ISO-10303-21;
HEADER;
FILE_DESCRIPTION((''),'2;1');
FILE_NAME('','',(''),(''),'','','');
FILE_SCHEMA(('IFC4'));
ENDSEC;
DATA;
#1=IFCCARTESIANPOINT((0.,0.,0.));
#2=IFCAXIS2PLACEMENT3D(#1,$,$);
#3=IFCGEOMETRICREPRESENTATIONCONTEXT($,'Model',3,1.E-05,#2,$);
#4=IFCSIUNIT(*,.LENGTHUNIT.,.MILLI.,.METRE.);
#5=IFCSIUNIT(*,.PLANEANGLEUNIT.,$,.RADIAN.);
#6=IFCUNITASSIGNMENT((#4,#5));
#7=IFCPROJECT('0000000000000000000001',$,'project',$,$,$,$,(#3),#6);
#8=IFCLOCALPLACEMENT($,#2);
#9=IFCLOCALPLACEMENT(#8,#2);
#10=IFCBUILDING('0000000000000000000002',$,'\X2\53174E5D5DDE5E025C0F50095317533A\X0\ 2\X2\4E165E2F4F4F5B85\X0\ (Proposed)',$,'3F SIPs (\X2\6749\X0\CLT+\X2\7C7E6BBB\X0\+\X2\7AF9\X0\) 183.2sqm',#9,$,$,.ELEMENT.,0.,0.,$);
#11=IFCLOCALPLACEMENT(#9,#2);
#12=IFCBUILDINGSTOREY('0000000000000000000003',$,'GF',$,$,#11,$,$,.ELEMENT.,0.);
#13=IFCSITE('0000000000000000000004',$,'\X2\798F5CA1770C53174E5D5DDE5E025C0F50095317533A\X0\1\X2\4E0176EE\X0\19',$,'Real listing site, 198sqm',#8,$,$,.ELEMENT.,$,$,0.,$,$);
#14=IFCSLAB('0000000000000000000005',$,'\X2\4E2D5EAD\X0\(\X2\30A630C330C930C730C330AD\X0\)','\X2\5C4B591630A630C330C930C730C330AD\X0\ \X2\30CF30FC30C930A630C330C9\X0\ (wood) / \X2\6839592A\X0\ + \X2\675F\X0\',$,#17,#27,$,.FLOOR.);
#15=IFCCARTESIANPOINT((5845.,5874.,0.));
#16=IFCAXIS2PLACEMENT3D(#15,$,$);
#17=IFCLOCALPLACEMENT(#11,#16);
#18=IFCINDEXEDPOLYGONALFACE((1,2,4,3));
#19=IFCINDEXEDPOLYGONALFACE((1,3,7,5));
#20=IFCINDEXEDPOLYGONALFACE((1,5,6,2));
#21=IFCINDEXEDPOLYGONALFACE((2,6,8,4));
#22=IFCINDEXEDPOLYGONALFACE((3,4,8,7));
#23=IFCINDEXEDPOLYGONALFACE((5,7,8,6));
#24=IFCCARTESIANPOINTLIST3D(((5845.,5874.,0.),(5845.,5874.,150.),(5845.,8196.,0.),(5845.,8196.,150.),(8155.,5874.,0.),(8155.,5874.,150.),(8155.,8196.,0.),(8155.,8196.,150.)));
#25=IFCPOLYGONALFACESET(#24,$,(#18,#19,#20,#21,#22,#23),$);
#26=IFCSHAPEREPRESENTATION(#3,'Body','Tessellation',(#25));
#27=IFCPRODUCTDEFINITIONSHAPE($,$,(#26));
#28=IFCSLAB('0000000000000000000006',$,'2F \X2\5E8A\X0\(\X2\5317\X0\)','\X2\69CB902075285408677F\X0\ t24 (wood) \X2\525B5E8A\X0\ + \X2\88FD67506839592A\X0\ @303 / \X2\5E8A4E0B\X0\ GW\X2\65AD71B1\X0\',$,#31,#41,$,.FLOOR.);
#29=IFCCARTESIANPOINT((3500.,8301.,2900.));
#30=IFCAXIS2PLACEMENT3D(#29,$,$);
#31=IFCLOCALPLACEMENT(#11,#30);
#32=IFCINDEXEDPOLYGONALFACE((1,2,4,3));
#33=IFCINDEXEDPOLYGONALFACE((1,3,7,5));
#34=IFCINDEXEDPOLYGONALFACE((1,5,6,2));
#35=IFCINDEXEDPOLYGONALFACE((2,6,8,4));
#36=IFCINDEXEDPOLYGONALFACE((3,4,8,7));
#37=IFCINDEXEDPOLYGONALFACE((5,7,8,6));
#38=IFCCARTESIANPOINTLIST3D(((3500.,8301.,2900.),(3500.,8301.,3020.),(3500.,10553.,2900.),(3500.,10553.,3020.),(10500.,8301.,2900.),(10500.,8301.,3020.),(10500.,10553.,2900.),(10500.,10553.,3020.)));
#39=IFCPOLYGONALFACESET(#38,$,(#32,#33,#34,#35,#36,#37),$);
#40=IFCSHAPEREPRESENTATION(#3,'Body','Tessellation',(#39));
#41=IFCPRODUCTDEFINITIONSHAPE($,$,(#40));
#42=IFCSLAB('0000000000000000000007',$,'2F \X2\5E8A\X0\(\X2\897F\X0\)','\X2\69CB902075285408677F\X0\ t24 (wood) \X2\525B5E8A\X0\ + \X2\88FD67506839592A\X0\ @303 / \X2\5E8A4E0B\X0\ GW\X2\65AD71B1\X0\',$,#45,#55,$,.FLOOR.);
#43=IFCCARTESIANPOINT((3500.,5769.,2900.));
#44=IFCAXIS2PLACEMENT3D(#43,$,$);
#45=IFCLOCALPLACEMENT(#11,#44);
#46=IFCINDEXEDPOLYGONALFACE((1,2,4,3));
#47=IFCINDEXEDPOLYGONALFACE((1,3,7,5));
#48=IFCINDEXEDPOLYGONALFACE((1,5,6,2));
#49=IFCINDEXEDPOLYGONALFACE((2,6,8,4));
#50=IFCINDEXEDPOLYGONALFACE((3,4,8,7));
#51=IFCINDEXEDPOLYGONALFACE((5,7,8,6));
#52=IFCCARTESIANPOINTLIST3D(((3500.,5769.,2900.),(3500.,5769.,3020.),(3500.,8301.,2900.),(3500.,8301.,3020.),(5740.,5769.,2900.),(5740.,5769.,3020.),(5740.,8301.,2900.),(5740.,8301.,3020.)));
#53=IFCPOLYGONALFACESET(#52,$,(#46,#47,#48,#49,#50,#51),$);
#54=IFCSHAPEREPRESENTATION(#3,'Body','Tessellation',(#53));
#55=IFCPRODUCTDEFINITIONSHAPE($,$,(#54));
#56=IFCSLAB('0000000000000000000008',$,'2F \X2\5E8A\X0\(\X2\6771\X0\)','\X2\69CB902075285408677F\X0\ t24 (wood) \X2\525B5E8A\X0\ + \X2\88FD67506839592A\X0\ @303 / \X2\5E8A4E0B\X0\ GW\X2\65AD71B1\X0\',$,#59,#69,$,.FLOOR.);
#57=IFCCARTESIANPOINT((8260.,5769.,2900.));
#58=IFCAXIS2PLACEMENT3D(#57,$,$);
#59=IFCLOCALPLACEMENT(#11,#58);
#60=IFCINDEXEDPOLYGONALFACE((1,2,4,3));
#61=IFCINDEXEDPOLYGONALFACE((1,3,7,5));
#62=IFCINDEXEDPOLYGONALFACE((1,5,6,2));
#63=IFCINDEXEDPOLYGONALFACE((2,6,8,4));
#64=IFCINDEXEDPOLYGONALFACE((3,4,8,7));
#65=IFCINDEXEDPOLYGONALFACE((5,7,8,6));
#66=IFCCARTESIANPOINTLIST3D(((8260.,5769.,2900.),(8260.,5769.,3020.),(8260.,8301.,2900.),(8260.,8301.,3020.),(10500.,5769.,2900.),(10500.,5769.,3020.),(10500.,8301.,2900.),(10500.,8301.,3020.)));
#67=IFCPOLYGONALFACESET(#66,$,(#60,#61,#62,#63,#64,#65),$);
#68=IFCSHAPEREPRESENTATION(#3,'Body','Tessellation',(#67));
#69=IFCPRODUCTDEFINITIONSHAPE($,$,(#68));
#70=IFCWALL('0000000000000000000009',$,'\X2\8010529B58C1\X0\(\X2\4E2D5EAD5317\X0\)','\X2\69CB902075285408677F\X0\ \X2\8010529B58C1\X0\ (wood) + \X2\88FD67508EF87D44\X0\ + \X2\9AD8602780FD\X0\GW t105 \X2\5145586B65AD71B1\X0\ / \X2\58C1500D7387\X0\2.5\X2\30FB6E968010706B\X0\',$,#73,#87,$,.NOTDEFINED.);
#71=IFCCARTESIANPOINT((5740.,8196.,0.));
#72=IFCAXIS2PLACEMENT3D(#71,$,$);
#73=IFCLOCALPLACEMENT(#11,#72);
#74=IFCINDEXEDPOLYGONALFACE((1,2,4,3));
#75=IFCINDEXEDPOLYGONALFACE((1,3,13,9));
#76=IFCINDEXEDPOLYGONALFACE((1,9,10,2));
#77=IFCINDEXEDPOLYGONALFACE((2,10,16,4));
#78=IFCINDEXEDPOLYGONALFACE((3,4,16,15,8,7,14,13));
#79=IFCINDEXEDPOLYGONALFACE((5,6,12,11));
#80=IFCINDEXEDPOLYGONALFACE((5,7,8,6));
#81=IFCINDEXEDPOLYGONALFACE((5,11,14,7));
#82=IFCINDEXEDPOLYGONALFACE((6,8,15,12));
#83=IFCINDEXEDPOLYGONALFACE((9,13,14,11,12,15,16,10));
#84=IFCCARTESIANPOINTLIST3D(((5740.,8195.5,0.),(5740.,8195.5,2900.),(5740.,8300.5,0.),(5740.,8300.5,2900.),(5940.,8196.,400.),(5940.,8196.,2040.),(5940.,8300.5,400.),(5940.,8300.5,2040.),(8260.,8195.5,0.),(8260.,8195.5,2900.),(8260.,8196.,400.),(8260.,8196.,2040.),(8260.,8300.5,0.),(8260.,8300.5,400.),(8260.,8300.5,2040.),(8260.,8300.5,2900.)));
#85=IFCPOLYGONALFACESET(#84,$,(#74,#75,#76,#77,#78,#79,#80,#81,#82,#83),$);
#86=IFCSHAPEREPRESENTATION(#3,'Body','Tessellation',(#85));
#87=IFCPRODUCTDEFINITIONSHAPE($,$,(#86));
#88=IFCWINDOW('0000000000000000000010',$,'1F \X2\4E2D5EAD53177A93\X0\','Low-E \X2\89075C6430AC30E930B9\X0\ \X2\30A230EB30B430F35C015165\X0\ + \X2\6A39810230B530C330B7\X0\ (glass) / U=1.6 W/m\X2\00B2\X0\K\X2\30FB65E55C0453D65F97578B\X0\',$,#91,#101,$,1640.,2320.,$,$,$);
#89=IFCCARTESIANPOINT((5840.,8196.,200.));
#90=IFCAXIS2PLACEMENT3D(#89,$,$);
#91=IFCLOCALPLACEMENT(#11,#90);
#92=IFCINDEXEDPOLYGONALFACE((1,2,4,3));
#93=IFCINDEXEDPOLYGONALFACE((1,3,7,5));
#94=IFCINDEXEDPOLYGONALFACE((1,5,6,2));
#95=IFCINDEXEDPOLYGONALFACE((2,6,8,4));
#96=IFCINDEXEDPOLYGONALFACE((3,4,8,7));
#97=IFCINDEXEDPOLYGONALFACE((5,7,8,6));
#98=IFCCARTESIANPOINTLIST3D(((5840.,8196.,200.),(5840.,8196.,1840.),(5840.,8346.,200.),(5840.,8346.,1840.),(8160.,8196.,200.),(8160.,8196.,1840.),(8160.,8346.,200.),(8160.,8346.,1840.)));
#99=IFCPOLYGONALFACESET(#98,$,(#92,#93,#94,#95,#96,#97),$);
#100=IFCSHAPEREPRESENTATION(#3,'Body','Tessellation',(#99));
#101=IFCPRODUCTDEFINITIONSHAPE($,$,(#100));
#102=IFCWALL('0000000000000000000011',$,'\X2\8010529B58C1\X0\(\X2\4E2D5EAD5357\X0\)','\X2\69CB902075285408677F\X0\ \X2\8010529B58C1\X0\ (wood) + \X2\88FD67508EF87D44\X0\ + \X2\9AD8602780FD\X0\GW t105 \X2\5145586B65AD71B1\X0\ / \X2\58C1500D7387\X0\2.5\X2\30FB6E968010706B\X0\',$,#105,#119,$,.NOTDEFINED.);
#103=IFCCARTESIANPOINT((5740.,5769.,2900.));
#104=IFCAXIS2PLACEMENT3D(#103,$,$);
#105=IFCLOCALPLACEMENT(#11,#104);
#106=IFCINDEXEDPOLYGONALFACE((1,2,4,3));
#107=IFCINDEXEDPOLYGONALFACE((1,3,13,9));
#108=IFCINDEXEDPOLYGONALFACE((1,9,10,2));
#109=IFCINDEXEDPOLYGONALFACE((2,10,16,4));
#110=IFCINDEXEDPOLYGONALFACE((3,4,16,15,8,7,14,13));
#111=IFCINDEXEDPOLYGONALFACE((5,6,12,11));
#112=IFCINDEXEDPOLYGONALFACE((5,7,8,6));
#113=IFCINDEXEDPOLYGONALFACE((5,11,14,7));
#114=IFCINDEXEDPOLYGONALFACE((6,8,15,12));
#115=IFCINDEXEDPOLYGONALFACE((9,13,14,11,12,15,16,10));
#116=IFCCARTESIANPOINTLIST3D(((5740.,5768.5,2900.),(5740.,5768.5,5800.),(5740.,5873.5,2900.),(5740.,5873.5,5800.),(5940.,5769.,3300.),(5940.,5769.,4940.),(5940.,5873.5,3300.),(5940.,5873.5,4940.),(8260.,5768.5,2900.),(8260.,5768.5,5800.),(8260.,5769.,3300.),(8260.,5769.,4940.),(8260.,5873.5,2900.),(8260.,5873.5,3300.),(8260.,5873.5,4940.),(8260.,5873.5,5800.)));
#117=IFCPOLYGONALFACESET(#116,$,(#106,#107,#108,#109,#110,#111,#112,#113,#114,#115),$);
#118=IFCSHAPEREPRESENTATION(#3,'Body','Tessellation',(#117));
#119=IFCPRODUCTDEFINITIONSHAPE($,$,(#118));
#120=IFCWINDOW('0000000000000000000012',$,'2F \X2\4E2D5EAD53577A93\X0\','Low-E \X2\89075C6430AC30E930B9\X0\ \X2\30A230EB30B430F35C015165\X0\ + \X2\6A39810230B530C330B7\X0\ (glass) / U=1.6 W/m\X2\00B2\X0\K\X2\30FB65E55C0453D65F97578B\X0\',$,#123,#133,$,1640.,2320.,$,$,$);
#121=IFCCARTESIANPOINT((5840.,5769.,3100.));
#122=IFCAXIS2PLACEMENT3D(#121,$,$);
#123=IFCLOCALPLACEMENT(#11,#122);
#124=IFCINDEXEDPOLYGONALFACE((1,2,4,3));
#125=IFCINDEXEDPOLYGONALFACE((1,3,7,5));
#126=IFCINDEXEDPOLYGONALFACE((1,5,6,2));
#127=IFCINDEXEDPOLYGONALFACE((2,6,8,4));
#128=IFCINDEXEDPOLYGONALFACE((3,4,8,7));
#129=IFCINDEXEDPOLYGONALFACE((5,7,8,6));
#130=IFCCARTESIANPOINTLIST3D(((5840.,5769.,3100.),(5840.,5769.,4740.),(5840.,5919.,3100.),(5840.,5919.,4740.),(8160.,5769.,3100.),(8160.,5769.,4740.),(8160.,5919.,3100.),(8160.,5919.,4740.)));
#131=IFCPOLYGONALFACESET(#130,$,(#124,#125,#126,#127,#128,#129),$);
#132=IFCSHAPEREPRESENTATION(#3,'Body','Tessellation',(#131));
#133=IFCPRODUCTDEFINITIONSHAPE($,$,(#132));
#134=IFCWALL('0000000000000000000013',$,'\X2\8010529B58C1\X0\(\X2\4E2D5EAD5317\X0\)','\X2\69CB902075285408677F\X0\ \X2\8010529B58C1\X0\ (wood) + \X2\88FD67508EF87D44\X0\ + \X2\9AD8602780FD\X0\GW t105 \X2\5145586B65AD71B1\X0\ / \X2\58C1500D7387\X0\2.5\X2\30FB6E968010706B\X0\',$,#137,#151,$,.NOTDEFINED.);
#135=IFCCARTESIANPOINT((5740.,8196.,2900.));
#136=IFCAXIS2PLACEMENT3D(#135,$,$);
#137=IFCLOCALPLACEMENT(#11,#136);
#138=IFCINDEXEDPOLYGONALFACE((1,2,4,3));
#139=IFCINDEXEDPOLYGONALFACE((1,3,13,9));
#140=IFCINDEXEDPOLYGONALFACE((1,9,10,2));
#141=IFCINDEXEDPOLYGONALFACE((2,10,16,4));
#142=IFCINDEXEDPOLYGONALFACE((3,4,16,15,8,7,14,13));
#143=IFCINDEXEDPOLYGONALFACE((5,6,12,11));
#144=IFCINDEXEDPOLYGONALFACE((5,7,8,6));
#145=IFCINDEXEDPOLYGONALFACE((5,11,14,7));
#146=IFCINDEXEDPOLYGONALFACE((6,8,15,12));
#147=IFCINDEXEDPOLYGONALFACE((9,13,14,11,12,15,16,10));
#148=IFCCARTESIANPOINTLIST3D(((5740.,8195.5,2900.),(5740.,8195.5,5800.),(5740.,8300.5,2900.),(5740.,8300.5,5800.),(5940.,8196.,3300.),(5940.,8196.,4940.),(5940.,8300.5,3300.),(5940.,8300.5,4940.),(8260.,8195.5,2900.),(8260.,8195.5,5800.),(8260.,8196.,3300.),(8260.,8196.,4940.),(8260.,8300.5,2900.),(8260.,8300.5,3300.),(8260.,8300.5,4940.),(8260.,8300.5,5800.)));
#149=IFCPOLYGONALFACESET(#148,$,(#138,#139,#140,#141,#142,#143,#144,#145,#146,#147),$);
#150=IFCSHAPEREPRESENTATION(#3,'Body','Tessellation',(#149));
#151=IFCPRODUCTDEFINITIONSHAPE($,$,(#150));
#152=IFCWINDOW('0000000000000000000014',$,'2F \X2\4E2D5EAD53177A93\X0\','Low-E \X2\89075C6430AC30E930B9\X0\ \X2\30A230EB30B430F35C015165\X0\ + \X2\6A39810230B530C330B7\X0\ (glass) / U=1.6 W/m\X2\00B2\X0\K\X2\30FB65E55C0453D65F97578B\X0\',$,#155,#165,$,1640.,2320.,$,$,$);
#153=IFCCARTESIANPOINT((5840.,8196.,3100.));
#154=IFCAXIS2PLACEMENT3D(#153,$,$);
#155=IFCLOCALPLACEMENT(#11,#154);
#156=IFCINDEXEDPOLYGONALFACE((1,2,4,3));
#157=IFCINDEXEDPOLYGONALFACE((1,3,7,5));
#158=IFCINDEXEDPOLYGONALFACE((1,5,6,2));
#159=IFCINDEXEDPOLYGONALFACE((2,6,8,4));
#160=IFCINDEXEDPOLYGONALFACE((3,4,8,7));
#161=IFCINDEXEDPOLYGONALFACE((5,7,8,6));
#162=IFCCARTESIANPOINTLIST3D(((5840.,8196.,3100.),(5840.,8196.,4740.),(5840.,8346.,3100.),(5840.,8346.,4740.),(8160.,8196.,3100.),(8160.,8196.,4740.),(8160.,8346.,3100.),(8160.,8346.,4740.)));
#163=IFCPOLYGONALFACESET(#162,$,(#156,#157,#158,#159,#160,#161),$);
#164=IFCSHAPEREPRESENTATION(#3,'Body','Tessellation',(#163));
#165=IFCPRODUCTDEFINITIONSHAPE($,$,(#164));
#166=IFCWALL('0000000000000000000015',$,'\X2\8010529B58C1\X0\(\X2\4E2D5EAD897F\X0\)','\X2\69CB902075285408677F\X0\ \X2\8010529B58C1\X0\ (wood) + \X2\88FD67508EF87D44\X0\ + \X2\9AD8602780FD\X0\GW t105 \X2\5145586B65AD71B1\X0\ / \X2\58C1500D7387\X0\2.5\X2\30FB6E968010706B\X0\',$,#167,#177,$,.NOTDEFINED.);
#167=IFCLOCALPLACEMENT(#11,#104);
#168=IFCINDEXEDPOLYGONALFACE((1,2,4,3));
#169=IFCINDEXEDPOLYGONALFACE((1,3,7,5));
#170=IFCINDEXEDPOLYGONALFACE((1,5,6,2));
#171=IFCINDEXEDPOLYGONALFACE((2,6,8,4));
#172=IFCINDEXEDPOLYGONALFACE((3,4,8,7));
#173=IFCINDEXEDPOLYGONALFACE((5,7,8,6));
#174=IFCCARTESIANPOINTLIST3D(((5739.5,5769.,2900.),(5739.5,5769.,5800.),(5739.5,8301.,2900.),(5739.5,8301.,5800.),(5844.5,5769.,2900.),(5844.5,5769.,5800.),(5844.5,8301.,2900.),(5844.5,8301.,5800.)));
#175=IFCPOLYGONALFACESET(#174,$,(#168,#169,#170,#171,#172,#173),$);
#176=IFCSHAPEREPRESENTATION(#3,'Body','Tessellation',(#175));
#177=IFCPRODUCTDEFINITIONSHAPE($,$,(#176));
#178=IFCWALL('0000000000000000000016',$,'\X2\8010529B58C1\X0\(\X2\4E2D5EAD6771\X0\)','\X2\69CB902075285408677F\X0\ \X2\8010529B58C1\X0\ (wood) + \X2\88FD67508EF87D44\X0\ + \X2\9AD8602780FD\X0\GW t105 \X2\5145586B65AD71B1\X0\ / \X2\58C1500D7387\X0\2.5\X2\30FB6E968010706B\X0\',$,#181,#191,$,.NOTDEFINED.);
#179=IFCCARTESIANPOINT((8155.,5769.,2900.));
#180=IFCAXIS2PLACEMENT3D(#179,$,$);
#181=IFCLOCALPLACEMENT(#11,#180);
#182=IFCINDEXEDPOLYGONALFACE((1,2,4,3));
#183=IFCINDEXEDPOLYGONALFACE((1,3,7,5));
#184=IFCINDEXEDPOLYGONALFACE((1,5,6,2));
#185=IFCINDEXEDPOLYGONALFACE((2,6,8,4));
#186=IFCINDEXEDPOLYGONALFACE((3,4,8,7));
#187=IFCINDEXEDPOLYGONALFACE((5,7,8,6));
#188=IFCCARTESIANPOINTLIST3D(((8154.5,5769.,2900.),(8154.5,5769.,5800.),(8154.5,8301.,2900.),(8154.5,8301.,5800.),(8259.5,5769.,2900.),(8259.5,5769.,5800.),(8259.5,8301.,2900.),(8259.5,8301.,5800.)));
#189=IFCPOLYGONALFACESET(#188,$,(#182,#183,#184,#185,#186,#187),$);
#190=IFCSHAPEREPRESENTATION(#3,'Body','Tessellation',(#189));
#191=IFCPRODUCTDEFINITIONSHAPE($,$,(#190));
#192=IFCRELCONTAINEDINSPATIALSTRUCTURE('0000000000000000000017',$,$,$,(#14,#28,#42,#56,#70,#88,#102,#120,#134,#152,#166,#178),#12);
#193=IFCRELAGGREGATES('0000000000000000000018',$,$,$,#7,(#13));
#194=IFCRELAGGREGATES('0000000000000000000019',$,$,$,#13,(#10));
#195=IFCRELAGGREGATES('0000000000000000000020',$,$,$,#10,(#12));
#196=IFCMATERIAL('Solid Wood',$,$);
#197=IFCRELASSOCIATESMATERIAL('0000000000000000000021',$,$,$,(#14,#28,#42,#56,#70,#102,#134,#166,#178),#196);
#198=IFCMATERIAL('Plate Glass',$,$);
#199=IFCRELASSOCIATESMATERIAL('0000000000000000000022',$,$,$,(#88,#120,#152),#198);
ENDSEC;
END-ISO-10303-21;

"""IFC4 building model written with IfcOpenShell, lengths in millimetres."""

from ifc_helpers import new_model, si_unit, frame, frame_2d, origin, place, context, project, spatial, rectangle, extrude, material, element, fill, save


model = new_model("IFC4")

# Units and contexts
model_context = context("Model", 3, precision=1e-05, world=origin())
ifc_project = project(units=[si_unit("LENGTHUNIT", "METRE", prefix="MILLI"), si_unit("PLANEANGLEUNIT", "RADIAN")], contexts=[model_context])

# Site, building, storey
site_placement = place(None, origin())
site = spatial("IfcSite", under=ifc_project, at=site_placement, Name="福岡県北九州市小倉北区1丁目19", ObjectType="Real listing site, 198sqm", CompositionType="ELEMENT", RefElevation=0.0)
building_placement = place(site_placement, origin())
building = spatial("IfcBuilding", under=site, at=building_placement, Name="北九州市小倉北区 2世帯住宅 (Proposed)", ObjectType="3F SIPs (杉CLT+籾殻+竹) 183.2sqm", CompositionType="ELEMENT", ElevationOfRefHeight=0.0, ElevationOfTerrain=0.0)
storey_placement = place(building_placement, origin())
storey = spatial("IfcBuildingStorey", under=building, at=storey_placement, Name="GF", CompositionType="ELEMENT", Elevation=0.0)

# Slabs
ifc_material_1 = material(Name="Solid Wood")
slab_1_placement = place(storey_placement, frame((5845.0, 5874.0, 0.0)))
element("IfcSlab", 1, at=slab_1_placement, inside=storey, material=ifc_material_1, Name="中庭(ウッドデッキ)", Description="屋外ウッドデッキ ハードウッド (wood) / 根太 + 束", PredefinedType="FLOOR", context=model_context, shape_type="SweptSolid", body=[
    extrude(rectangle(XDim=2310.0, YDim=2322.0, at=frame_2d((1155.0, 1161.0))), frame((5845.0, 5874.0, 0.0)), (0.0, 0.0, 1.0), 150.0),
])
slab_2_placement = place(storey_placement, frame((3500.0, 8301.0, 2900.0)))
element("IfcSlab", 2, at=slab_2_placement, inside=storey, material=ifc_material_1, Name="2F 床(北)", Description="構造用合板 t24 (wood) 剛床 + 製材根太 @303 / 床下 GW断熱", PredefinedType="FLOOR", context=model_context, shape_type="SweptSolid", body=[
    extrude(rectangle(XDim=7000.0, YDim=2252.0, at=frame_2d((3500.0, 1126.0))), frame((3500.0, 8301.0, 2900.0)), (0.0, 0.0, 1.0), 120.0),
])
slab_3_placement = place(storey_placement, frame((3500.0, 5769.0, 2900.0)))
element("IfcSlab", 3, at=slab_3_placement, inside=storey, material=ifc_material_1, Name="2F 床(西)", Description="構造用合板 t24 (wood) 剛床 + 製材根太 @303 / 床下 GW断熱", PredefinedType="FLOOR", context=model_context, shape_type="SweptSolid", body=[
    extrude(rectangle(XDim=2240.0, YDim=2532.0, at=frame_2d((1120.0, 1266.0))), frame((3500.0, 5769.0, 2900.0)), (0.0, 0.0, 1.0), 120.0),
])
slab_4_placement = place(storey_placement, frame((8260.0, 5769.0, 2900.0)))
element("IfcSlab", 4, at=slab_4_placement, inside=storey, material=ifc_material_1, Name="2F 床(東)", Description="構造用合板 t24 (wood) 剛床 + 製材根太 @303 / 床下 GW断熱", PredefinedType="FLOOR", context=model_context, shape_type="SweptSolid", body=[
    extrude(rectangle(XDim=2240.0, YDim=2532.0, at=frame_2d((1120.0, 1266.0))), frame((8260.0, 5769.0, 2900.0)), (0.0, 0.0, 1.0), 120.0),
])

# Wall, opening, window
wall_1_placement = place(storey_placement, frame((5740.0, 8196.0, 0.0)))
wall_1 = element("IfcWall", 5, at=wall_1_placement, inside=storey, material=ifc_material_1, Name="耐力壁(中庭北)", Description="構造用合板 耐力壁 (wood) + 製材軸組 + 高性能GW t105 充填断熱 / 壁倍率2.5・準耐火", PredefinedType="NOTDEFINED", context=model_context, shape_type="SweptSolid", body=[
    extrude(rectangle(XDim=2520.0, YDim=105.0, at=frame_2d((1260.0, 52.0))), frame((5740.0, 8196.0, 0.0)), (0.0, 0.0, 1.0), 2900.0),
])
opening_1_placement = place(storey_placement, frame((5840.0, 8196.0, 200.0)))
opening_1 = element("IfcOpeningElement", 6, at=opening_1_placement, cuts=wall_1, PredefinedType="NOTDEFINED", context=model_context, shape_type="SweptSolid", body=[
    extrude(rectangle(XDim=2320.0, YDim=150.0, at=frame_2d((1160.0, 75.0))), frame((5840.0, 8196.0, 200.0)), (0.0, 0.0, 1.0), 1640.0),
])
ifc_material_2 = material(Name="Plate Glass")
window_1_placement = place(storey_placement, frame((5840.0, 8196.0, 200.0)))
window_1 = element("IfcWindow", 7, at=window_1_placement, inside=storey, material=ifc_material_2, Name="1F 中庭北窓", Description="Low-E 複層ガラス アルゴン封入 + 樹脂サッシ (glass) / U=1.6 W/m²K・日射取得型", OverallHeight=1640.0, OverallWidth=2320.0, context=model_context, shape_type="SweptSolid", body=[
    extrude(rectangle(XDim=2320.0, YDim=150.0, at=frame_2d((1160.0, 75.0))), frame((5840.0, 8196.0, 200.0)), (0.0, 0.0, 1.0), 1640.0),
])
fill(opening_1, window_1)

# Walls, openings, windows
wall_2_placement = place(storey_placement, frame((5740.0, 5769.0, 2900.0)))
wall_2 = element("IfcWall", 8, at=wall_2_placement, inside=storey, material=ifc_material_1, Name="耐力壁(中庭南)", Description="構造用合板 耐力壁 (wood) + 製材軸組 + 高性能GW t105 充填断熱 / 壁倍率2.5・準耐火", PredefinedType="NOTDEFINED", context=model_context, shape_type="SweptSolid", body=[
    extrude(rectangle(XDim=2520.0, YDim=105.0, at=frame_2d((1260.0, 52.0))), frame((5740.0, 5769.0, 2900.0)), (0.0, 0.0, 1.0), 2900.0),
])
opening_2_placement = place(storey_placement, frame((5840.0, 5769.0, 3100.0)))
opening_2 = element("IfcOpeningElement", 9, at=opening_2_placement, cuts=wall_2, PredefinedType="NOTDEFINED", context=model_context, shape_type="SweptSolid", body=[
    extrude(rectangle(XDim=2320.0, YDim=150.0, at=frame_2d((1160.0, 75.0))), frame((5840.0, 5769.0, 3100.0)), (0.0, 0.0, 1.0), 1640.0),
])
window_2_placement = place(storey_placement, frame((5840.0, 5769.0, 3100.0)))
window_2 = element("IfcWindow", 10, at=window_2_placement, inside=storey, material=ifc_material_2, Name="2F 中庭南窓", Description="Low-E 複層ガラス アルゴン封入 + 樹脂サッシ (glass) / U=1.6 W/m²K・日射取得型", OverallHeight=1640.0, OverallWidth=2320.0, context=model_context, shape_type="SweptSolid", body=[
    extrude(rectangle(XDim=2320.0, YDim=150.0, at=frame_2d((1160.0, 75.0))), frame((5840.0, 5769.0, 3100.0)), (0.0, 0.0, 1.0), 1640.0),
])
fill(opening_2, window_2)
wall_3_placement = place(storey_placement, frame((5740.0, 8196.0, 2900.0)))
wall_3 = element("IfcWall", 11, at=wall_3_placement, inside=storey, material=ifc_material_1, Name="耐力壁(中庭北)", Description="構造用合板 耐力壁 (wood) + 製材軸組 + 高性能GW t105 充填断熱 / 壁倍率2.5・準耐火", PredefinedType="NOTDEFINED", context=model_context, shape_type="SweptSolid", body=[
    extrude(rectangle(XDim=2520.0, YDim=105.0, at=frame_2d((1260.0, 52.0))), frame((5740.0, 8196.0, 2900.0)), (0.0, 0.0, 1.0), 2900.0),
])
opening_3_placement = place(storey_placement, frame((5840.0, 8196.0, 3100.0)))
opening_3 = element("IfcOpeningElement", 12, at=opening_3_placement, cuts=wall_3, PredefinedType="NOTDEFINED", context=model_context, shape_type="SweptSolid", body=[
    extrude(rectangle(XDim=2320.0, YDim=150.0, at=frame_2d((1160.0, 75.0))), frame((5840.0, 8196.0, 3100.0)), (0.0, 0.0, 1.0), 1640.0),
])
window_3_placement = place(storey_placement, frame((5840.0, 8196.0, 3100.0)))
window_3 = element("IfcWindow", 13, at=window_3_placement, inside=storey, material=ifc_material_2, Name="2F 中庭北窓", Description="Low-E 複層ガラス アルゴン封入 + 樹脂サッシ (glass) / U=1.6 W/m²K・日射取得型", OverallHeight=1640.0, OverallWidth=2320.0, context=model_context, shape_type="SweptSolid", body=[
    extrude(rectangle(XDim=2320.0, YDim=150.0, at=frame_2d((1160.0, 75.0))), frame((5840.0, 8196.0, 3100.0)), (0.0, 0.0, 1.0), 1640.0),
])
fill(opening_3, window_3)

# Walls
wall_4_placement = place(storey_placement, frame((5740.0, 5769.0, 2900.0)))
element("IfcWall", 14, at=wall_4_placement, inside=storey, material=ifc_material_1, Name="耐力壁(中庭西)", Description="構造用合板 耐力壁 (wood) + 製材軸組 + 高性能GW t105 充填断熱 / 壁倍率2.5・準耐火", PredefinedType="NOTDEFINED", context=model_context, shape_type="SweptSolid", body=[
    extrude(rectangle(XDim=105.0, YDim=2532.0, at=frame_2d((52.0, 1266.0))), frame((5740.0, 5769.0, 2900.0)), (0.0, 0.0, 1.0), 2900.0),
])
wall_5_placement = place(storey_placement, frame((8155.0, 5769.0, 2900.0)))
element("IfcWall", 15, at=wall_5_placement, inside=storey, material=ifc_material_1, Name="耐力壁(中庭東)", Description="構造用合板 耐力壁 (wood) + 製材軸組 + 高性能GW t105 充填断熱 / 壁倍率2.5・準耐火", PredefinedType="NOTDEFINED", context=model_context, shape_type="SweptSolid", body=[
    extrude(rectangle(XDim=105.0, YDim=2532.0, at=frame_2d((52.0, 1266.0))), frame((8155.0, 5769.0, 2900.0)), (0.0, 0.0, 1.0), 2900.0),
])

save(model, "model.ifc")
